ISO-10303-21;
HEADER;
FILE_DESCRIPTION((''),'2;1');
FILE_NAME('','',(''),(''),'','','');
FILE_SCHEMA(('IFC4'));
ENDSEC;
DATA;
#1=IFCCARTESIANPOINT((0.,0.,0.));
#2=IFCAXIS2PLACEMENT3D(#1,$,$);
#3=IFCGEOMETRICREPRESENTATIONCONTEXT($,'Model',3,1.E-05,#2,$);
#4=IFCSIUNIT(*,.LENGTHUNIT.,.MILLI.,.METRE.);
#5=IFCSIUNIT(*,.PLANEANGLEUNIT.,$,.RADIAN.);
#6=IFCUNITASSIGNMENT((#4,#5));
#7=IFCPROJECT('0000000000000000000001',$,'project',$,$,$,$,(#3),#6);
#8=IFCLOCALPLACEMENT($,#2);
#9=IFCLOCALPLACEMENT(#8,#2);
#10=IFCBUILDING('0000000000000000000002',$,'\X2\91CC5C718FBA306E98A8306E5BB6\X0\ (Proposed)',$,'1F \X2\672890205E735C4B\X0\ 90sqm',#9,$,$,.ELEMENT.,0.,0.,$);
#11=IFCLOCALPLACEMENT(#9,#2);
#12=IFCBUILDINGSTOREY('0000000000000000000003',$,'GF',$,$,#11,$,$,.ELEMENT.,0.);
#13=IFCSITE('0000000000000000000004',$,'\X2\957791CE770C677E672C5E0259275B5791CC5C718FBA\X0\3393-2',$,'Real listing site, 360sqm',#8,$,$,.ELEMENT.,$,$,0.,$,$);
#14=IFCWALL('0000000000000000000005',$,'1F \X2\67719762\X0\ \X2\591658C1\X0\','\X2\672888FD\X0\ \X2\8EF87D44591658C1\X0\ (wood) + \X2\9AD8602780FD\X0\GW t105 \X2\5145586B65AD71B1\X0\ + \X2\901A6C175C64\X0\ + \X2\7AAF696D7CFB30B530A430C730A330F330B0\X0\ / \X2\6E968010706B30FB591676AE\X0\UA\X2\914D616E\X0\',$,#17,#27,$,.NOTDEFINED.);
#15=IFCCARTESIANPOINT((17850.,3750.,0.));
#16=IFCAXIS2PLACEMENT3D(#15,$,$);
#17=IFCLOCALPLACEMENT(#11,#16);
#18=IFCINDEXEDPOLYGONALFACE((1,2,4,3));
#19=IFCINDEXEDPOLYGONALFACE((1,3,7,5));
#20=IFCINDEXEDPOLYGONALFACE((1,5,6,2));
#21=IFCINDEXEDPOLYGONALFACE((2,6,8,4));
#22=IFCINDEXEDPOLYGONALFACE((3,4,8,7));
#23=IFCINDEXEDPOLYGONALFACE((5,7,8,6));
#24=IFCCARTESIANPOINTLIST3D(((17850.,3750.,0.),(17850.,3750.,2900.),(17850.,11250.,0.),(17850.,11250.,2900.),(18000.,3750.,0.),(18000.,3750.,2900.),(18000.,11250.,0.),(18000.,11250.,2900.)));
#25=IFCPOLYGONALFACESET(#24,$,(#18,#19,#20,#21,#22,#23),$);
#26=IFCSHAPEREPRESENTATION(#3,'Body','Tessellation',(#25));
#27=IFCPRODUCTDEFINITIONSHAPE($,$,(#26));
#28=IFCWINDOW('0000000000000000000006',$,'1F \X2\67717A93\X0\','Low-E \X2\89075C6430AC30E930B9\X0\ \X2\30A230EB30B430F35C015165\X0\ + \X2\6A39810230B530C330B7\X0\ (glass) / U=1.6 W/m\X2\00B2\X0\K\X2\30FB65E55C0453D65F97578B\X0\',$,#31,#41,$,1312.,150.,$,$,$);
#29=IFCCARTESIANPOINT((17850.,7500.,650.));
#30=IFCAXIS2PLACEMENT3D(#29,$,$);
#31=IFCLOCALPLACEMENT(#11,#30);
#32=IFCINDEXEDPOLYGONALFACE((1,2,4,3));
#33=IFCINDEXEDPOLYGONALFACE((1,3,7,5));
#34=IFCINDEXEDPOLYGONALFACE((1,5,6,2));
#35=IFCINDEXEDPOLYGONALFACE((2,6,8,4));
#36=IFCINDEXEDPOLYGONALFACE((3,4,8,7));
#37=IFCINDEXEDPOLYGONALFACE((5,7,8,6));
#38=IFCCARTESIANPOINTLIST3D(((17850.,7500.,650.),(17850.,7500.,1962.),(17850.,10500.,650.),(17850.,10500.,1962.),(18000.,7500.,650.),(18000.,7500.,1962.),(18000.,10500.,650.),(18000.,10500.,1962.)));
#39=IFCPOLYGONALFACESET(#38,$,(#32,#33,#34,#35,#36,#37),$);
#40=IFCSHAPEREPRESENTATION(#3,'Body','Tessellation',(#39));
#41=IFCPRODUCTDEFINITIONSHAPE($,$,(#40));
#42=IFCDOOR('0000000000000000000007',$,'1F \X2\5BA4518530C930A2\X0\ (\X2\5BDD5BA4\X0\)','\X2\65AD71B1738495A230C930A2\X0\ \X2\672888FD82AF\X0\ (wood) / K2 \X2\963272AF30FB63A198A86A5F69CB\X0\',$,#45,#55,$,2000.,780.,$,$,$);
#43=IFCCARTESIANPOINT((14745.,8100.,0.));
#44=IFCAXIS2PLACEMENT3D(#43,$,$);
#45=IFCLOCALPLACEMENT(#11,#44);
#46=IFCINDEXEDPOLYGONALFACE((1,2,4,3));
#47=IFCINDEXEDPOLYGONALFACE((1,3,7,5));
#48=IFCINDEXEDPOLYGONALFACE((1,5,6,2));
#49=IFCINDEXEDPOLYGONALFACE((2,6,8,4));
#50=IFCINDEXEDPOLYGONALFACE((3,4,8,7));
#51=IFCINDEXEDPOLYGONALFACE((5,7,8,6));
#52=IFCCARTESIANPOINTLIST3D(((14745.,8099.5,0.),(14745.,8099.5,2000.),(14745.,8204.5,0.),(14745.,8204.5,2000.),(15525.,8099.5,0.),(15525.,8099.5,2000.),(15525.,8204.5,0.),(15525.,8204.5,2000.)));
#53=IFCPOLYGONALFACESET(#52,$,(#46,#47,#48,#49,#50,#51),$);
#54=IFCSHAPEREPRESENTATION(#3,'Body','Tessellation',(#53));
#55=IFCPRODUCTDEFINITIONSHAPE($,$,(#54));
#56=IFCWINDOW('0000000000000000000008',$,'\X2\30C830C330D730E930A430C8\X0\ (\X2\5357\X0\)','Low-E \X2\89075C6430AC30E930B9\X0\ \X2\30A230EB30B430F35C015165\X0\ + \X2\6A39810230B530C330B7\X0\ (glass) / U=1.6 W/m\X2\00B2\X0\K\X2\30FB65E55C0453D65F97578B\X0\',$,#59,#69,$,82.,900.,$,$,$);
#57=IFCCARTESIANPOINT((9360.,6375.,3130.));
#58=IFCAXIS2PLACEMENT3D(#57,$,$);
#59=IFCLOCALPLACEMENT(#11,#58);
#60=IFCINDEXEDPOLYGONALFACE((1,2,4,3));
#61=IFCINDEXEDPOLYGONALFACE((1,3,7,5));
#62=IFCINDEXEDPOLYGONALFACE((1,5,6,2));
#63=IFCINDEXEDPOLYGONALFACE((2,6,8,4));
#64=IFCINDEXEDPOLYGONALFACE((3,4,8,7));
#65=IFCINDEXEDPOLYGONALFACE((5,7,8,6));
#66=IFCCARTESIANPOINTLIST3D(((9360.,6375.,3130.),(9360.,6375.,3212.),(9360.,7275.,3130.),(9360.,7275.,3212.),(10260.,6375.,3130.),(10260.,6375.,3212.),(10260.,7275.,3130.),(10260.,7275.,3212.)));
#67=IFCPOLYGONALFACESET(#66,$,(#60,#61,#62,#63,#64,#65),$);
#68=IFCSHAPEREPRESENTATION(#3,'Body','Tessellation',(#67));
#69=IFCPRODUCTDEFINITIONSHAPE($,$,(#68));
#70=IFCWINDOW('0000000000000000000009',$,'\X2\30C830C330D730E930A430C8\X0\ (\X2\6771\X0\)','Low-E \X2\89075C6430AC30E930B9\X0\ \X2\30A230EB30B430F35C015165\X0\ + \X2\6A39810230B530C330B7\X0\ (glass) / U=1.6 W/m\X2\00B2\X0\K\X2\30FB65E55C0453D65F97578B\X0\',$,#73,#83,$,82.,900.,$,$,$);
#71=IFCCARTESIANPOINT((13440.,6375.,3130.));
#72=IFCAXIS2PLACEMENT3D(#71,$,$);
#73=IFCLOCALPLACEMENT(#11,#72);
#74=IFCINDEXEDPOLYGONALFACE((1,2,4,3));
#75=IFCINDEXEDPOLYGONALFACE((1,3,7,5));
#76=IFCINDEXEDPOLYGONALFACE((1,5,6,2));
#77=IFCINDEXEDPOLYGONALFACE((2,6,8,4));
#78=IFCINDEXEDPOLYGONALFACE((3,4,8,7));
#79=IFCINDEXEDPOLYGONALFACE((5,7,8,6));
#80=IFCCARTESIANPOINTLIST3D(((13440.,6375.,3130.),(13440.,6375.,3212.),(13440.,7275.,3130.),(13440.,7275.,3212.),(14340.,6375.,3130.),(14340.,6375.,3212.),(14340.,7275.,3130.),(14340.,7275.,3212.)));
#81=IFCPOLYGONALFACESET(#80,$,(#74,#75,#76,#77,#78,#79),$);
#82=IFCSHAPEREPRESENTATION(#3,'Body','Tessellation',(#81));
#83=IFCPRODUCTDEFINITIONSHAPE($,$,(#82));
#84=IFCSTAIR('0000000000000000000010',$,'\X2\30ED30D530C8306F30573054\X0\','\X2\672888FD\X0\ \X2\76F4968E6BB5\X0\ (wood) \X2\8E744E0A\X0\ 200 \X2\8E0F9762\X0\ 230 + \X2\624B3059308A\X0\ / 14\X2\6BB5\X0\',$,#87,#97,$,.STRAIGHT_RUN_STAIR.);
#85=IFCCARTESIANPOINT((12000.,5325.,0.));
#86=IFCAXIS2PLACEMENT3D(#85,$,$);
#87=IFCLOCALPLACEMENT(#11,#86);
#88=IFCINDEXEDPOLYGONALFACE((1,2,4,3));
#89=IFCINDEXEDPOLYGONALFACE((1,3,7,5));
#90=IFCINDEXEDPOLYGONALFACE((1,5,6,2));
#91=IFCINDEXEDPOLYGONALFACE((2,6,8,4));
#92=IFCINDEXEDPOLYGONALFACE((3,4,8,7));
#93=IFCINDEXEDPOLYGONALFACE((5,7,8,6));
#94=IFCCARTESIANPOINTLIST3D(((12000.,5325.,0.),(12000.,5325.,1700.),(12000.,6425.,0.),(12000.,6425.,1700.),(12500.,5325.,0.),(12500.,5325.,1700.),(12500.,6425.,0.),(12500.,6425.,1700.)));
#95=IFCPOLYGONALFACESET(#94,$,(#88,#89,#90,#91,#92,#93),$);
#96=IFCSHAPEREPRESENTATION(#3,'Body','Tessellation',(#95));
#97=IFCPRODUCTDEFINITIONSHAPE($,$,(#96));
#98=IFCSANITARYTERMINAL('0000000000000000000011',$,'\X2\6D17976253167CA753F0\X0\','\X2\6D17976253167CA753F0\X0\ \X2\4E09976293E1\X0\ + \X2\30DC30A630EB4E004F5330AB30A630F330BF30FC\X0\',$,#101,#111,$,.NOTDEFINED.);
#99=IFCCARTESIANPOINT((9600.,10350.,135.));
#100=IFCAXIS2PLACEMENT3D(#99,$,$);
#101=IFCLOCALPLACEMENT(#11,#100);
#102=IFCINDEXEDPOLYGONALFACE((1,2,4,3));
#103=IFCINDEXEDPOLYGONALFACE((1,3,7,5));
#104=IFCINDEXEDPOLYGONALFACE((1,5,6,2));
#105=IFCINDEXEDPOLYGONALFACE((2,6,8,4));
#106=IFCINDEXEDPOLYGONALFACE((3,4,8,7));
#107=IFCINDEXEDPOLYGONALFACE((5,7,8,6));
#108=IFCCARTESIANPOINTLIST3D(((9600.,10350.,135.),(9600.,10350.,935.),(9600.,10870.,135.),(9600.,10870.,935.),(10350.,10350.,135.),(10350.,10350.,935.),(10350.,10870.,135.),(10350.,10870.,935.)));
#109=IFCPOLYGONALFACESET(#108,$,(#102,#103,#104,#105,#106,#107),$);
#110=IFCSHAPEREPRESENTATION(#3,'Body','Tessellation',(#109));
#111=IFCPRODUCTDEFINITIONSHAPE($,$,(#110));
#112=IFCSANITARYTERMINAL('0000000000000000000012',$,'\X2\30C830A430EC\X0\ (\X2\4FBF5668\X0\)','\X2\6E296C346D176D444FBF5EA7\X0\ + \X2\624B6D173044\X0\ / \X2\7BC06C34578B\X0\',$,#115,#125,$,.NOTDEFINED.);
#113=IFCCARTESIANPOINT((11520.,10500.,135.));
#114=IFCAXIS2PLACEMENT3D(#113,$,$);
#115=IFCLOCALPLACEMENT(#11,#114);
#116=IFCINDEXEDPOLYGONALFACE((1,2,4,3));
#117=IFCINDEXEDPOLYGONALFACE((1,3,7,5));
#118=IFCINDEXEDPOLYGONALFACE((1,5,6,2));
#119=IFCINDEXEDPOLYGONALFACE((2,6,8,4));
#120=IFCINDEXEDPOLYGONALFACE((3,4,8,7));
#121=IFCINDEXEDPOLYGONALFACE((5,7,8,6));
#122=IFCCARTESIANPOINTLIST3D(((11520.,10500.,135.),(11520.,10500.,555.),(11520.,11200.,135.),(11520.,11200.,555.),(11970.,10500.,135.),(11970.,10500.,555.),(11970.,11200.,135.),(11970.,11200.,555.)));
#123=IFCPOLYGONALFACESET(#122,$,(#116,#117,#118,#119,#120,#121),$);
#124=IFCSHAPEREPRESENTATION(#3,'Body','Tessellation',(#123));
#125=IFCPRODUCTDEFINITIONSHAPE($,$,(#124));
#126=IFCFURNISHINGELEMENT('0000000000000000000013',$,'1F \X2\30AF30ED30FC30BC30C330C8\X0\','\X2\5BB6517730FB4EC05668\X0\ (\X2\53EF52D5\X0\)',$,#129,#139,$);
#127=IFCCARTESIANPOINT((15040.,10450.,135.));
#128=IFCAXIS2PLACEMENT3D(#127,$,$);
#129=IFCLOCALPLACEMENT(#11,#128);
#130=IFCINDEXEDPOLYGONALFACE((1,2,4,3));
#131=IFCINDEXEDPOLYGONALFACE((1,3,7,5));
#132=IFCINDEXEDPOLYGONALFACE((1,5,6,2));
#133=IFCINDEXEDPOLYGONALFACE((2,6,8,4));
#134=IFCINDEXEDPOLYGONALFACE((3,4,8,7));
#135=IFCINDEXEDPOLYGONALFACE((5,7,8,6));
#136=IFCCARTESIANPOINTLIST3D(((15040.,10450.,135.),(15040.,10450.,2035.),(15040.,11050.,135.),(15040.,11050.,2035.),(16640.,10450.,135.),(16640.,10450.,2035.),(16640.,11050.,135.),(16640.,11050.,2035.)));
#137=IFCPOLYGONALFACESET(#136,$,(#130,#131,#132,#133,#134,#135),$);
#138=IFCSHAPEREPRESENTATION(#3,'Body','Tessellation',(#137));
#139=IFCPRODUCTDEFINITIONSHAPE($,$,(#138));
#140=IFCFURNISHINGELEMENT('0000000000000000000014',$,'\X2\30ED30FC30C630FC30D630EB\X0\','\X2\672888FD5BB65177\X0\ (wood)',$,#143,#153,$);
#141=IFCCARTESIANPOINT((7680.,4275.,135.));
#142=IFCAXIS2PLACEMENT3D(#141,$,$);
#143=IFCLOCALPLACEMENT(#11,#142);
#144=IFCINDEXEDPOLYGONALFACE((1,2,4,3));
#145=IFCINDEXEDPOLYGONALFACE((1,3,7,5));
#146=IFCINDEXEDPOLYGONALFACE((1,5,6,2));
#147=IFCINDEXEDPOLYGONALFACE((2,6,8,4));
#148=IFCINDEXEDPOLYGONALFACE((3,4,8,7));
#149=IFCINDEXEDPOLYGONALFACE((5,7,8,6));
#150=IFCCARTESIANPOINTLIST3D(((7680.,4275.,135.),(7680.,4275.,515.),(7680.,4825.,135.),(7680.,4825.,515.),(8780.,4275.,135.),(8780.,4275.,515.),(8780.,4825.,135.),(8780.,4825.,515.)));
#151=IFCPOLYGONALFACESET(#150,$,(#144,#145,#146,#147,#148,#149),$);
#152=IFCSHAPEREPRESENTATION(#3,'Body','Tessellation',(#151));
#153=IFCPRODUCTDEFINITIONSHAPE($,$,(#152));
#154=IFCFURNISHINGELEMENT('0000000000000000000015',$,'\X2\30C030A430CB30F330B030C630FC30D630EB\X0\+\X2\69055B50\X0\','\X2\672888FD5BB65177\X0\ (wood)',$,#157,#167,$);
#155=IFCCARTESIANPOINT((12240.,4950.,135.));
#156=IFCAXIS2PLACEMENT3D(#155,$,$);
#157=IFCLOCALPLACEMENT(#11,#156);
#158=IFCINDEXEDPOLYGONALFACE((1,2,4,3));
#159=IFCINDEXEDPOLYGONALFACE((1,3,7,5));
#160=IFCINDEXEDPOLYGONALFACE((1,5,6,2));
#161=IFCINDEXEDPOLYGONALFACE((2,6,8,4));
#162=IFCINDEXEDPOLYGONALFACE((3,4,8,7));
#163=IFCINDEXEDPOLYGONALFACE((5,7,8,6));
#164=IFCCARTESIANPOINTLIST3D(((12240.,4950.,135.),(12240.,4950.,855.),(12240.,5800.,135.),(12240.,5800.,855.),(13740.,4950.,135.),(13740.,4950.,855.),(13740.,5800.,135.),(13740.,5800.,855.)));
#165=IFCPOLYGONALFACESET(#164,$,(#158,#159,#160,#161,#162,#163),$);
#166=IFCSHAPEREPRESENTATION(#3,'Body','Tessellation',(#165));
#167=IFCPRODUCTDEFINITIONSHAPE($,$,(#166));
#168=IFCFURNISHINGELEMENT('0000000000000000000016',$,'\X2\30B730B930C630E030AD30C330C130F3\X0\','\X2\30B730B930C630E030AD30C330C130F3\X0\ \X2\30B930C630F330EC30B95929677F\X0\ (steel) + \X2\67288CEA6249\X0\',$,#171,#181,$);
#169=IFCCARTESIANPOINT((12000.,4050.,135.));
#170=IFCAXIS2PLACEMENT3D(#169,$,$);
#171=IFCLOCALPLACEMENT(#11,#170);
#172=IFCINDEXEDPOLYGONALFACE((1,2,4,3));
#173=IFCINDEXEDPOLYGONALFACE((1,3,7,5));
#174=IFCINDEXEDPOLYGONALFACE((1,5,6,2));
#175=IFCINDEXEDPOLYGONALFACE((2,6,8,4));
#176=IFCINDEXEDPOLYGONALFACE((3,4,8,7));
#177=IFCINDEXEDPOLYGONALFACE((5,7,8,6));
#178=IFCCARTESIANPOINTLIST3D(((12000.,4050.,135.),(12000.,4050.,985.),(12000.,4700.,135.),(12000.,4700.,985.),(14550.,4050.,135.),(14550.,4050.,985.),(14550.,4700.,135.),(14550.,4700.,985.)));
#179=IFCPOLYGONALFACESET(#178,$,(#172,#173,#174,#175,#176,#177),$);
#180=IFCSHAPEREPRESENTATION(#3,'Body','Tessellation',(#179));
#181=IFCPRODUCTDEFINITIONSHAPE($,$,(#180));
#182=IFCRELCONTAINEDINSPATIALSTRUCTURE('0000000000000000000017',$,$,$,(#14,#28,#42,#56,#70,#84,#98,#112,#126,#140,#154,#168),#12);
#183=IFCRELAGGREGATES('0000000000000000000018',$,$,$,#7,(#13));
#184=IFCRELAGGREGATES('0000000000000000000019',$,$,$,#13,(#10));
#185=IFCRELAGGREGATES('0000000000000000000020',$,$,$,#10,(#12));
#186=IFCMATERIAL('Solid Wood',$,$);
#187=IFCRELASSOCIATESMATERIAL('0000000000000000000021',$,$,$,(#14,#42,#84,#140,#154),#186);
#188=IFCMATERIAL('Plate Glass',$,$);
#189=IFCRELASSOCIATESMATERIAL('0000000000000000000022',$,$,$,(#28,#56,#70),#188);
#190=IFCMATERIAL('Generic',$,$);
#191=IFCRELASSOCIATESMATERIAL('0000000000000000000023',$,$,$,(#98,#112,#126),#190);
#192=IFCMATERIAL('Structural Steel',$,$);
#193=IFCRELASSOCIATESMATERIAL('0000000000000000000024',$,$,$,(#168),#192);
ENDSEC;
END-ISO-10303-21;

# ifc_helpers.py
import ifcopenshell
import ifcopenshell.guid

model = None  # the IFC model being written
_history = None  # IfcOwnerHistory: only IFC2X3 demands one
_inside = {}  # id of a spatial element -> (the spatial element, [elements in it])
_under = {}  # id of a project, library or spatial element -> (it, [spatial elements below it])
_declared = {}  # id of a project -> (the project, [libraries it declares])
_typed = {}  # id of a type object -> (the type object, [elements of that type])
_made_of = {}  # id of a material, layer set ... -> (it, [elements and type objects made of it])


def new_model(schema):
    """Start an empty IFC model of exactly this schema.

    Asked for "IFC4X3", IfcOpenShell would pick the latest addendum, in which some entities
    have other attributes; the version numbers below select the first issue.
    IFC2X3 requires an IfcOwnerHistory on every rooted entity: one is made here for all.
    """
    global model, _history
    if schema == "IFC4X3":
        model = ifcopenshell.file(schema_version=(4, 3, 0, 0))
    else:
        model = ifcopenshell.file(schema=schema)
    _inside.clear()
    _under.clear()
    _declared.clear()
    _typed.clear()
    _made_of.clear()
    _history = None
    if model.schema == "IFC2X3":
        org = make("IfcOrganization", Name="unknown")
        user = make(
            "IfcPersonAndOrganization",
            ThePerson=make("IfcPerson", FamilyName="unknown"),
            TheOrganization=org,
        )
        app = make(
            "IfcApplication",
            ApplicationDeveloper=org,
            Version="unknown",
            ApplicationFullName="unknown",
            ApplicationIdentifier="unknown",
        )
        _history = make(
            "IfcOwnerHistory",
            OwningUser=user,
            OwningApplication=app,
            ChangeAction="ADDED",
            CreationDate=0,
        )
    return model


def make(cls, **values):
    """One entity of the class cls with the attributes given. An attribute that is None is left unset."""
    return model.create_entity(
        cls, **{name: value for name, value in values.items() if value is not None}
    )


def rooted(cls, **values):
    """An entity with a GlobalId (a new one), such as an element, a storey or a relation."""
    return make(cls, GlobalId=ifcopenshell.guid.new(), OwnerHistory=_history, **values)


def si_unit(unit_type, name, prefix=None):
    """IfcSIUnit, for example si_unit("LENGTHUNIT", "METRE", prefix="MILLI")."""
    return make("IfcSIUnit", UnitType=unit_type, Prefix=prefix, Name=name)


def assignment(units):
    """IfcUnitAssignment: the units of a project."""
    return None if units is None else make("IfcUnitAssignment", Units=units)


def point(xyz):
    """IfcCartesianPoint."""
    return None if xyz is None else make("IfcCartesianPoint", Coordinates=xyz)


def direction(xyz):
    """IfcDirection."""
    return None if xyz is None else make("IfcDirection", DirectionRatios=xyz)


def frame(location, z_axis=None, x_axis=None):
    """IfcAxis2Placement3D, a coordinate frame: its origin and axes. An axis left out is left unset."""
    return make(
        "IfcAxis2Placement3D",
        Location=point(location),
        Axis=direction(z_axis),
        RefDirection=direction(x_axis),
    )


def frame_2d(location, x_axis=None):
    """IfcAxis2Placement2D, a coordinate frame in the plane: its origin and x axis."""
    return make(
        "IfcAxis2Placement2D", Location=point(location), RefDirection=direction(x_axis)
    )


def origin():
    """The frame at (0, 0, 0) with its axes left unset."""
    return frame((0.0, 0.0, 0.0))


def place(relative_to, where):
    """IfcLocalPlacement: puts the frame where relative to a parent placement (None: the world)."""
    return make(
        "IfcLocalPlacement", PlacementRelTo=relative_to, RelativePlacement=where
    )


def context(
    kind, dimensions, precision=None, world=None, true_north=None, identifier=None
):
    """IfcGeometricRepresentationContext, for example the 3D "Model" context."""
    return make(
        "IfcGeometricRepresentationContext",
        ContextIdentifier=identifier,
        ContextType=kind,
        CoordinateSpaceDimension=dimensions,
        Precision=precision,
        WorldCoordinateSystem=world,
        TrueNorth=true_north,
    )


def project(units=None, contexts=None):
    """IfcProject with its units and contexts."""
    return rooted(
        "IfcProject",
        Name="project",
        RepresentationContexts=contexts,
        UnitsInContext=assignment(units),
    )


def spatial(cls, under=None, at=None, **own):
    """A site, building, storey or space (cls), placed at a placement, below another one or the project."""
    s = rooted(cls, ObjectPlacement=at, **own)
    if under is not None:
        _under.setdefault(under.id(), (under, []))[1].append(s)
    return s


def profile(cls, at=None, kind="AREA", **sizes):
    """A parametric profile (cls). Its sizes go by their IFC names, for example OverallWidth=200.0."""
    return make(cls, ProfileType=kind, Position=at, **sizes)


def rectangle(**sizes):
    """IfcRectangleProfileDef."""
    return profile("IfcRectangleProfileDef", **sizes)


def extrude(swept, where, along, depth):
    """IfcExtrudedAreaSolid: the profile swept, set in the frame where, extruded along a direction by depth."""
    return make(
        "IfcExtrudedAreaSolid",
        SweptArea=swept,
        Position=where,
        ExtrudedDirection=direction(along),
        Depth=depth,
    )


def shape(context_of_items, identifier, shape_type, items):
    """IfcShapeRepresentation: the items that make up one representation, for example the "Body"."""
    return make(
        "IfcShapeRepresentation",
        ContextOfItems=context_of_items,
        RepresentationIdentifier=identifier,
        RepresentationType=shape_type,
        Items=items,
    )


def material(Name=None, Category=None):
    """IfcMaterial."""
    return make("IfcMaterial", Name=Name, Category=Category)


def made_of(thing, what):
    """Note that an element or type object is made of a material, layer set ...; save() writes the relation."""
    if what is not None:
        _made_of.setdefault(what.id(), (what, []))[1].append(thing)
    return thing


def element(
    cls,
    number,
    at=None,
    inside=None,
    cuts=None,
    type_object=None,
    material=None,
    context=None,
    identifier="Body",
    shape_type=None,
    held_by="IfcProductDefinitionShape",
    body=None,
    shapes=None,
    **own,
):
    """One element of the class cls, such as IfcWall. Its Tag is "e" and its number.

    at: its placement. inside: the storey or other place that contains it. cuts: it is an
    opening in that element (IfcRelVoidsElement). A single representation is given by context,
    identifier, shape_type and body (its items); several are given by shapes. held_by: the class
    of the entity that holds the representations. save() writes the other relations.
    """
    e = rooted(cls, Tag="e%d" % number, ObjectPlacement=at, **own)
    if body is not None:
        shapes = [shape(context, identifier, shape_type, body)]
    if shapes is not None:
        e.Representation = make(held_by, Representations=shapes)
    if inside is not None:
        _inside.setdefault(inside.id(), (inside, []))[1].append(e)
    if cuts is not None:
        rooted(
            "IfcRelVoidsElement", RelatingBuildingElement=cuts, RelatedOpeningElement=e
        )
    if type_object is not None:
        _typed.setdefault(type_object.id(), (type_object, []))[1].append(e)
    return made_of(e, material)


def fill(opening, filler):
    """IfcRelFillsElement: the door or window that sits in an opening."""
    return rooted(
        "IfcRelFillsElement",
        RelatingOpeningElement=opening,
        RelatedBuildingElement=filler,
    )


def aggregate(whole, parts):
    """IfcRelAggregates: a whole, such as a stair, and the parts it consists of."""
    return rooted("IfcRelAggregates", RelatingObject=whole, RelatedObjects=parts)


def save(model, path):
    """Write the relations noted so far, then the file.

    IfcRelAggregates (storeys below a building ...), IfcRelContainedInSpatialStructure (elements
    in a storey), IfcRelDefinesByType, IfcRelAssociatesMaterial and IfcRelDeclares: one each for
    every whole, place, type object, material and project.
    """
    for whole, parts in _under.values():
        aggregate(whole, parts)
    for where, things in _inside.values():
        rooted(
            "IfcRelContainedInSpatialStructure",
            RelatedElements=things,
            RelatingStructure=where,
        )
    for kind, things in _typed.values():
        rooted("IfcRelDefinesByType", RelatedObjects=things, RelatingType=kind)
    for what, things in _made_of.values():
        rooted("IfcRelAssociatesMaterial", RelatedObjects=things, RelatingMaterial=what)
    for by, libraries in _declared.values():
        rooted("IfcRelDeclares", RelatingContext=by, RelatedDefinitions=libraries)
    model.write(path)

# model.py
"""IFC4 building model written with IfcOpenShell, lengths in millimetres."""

from ifc_helpers import new_model, si_unit, frame, frame_2d, origin, place, context, project, spatial, rectangle, extrude, material, element, fill, save


model = new_model("IFC4")

# Units and contexts
model_context = context("Model", 3, precision=1e-05, world=origin())
ifc_project = project(units=[si_unit("LENGTHUNIT", "METRE", prefix="MILLI"), si_unit("PLANEANGLEUNIT", "RADIAN")], contexts=[model_context])

# Site, building, storey
site_placement = place(None, origin())
site = spatial("IfcSite", under=ifc_project, at=site_placement, Name="長野県松本市大字里山辺3393-2", ObjectType="Real listing site, 360sqm", CompositionType="ELEMENT", RefElevation=0.0)
building_placement = place(site_placement, origin())
building = spatial("IfcBuilding", under=site, at=building_placement, Name="里山辺の風の家 (Proposed)", ObjectType="1F 木造平屋 90sqm", CompositionType="ELEMENT", ElevationOfRefHeight=0.0, ElevationOfTerrain=0.0)
storey_placement = place(building_placement, origin())
storey = spatial("IfcBuildingStorey", under=building, at=storey_placement, Name="GF", CompositionType="ELEMENT", Elevation=0.0)

# Wall, opening, window
ifc_material_1 = material(Name="Solid Wood")
wall_1_placement = place(storey_placement, frame((17850.0, 3750.0, 0.0)))
wall_1 = element("IfcWall", 1, at=wall_1_placement, inside=storey, material=ifc_material_1, Name="1F 東面 外壁", Description="木製 軸組外壁 (wood) + 高性能GW t105 充填断熱 + 通気層 + 窯業系サイディング / 準耐火・外皮UA配慮", PredefinedType="NOTDEFINED", context=model_context, shape_type="SweptSolid", body=[
    extrude(rectangle(XDim=150.0, YDim=7500.0, at=frame_2d((75.0, 3750.0))), frame((17850.0, 3750.0, 0.0)), (0.0, 0.0, 1.0), 2900.0),
])
opening_placement = place(storey_placement, frame((17850.0, 7500.0, 650.0)))
opening = element("IfcOpeningElement", 2, at=opening_placement, cuts=wall_1, PredefinedType="NOTDEFINED", context=model_context, shape_type="SweptSolid", body=[
    extrude(rectangle(XDim=150.0, YDim=3000.0, at=frame_2d((75.0, 1500.0))), frame((17850.0, 7500.0, 650.0)), (0.0, 0.0, 1.0), 1312.0),
])
ifc_material_2 = material(Name="Plate Glass")
window_1_placement = place(storey_placement, frame((17850.0, 7500.0, 650.0)))
window_1 = element("IfcWindow", 3, at=window_1_placement, inside=storey, material=ifc_material_2, Name="1F 東窓", Description="Low-E 複層ガラス アルゴン封入 + 樹脂サッシ (glass) / U=1.6 W/m²K・日射取得型", OverallHeight=1312.0, OverallWidth=150.0, context=model_context, shape_type="SweptSolid", body=[
    extrude(rectangle(XDim=150.0, YDim=3000.0, at=frame_2d((75.0, 1500.0))), frame((17850.0, 7500.0, 650.0)), (0.0, 0.0, 1.0), 1312.0),
])
fill(opening, window_1)

# Door
door_placement = place(storey_placement, frame((14745.0, 8100.0, 0.0)))
element("IfcDoor", 4, at=door_placement, inside=storey, material=ifc_material_1, Name="1F 室内ドア (寝室)", Description="断熱玄関ドア 木製芯 (wood) / K2 防犯・採風機構", OverallHeight=2000.0, OverallWidth=780.0, context=model_context, shape_type="SweptSolid", body=[
    extrude(rectangle(XDim=780.0, YDim=105.0, at=frame_2d((390.0, 52.0))), frame((14745.0, 8100.0, 0.0)), (0.0, 0.0, 1.0), 2000.0),
])

# Windows
window_2_placement = place(storey_placement, frame((9360.0, 6375.0, 3130.0)))
element("IfcWindow", 5, at=window_2_placement, inside=storey, material=ifc_material_2, Name="トップライト (南)", Description="Low-E 複層ガラス アルゴン封入 + 樹脂サッシ (glass) / U=1.6 W/m²K・日射取得型", OverallHeight=82.0, OverallWidth=900.0, context=model_context, shape_type="SweptSolid", body=[
    extrude(rectangle(XDim=900.0, YDim=900.0, at=frame_2d((450.0, 450.0))), frame((9360.0, 6375.0, 3130.0)), (0.0, 0.0, 1.0), 82.0),
])
window_3_placement = place(storey_placement, frame((13440.0, 6375.0, 3130.0)))
element("IfcWindow", 6, at=window_3_placement, inside=storey, material=ifc_material_2, Name="トップライト (東)", Description="Low-E 複層ガラス アルゴン封入 + 樹脂サッシ (glass) / U=1.6 W/m²K・日射取得型", OverallHeight=82.0, OverallWidth=900.0, context=model_context, shape_type="SweptSolid", body=[
    extrude(rectangle(XDim=900.0, YDim=900.0, at=frame_2d((450.0, 450.0))), frame((13440.0, 6375.0, 3130.0)), (0.0, 0.0, 1.0), 82.0),
])

# Stair
stair_placement = place(storey_placement, frame((12000.0, 5325.0, 0.0)))
element("IfcStair", 7, at=stair_placement, inside=storey, material=ifc_material_1, Name="ロフトはしご", Description="木製 直階段 (wood) 蹴上 200 踏面 230 + 手すり / 14段", PredefinedType="STRAIGHT_RUN_STAIR", context=model_context, shape_type="SweptSolid", body=[
    extrude(rectangle(XDim=500.0, YDim=1100.0, at=frame_2d((250.0, 550.0))), frame((12000.0, 5325.0, 0.0)), (0.0, 0.0, 1.0), 1700.0),
])

# Sanitary terminals
ifc_material_3 = material(Name="Generic")
sanitary_terminal_1_placement = place(storey_placement, frame((9600.0, 10350.0, 135.0)))
element("IfcSanitaryTerminal", 8, at=sanitary_terminal_1_placement, inside=storey, material=ifc_material_3, Name="洗面化粧台", Description="洗面化粧台 三面鏡 + ボウル一体カウンター", PredefinedType="NOTDEFINED", context=model_context, shape_type="SweptSolid", body=[
    extrude(rectangle(XDim=750.0, YDim=520.0, at=frame_2d((375.0, 260.0))), frame((9600.0, 10350.0, 135.0)), (0.0, 0.0, 1.0), 800.0),
])
sanitary_terminal_2_placement = place(storey_placement, frame((11520.0, 10500.0, 135.0)))
element("IfcSanitaryTerminal", 9, at=sanitary_terminal_2_placement, inside=storey, material=ifc_material_3, Name="トイレ (便器)", Description="温水洗浄便座 + 手洗い / 節水型", PredefinedType="NOTDEFINED", context=model_context, shape_type="SweptSolid", body=[
    extrude(rectangle(XDim=450.0, YDim=700.0, at=frame_2d((225.0, 350.0))), frame((11520.0, 10500.0, 135.0)), (0.0, 0.0, 1.0), 420.0),
])

# Furnishing elements
furnishing_1_placement = place(storey_placement, frame((15040.0, 10450.0, 135.0)))
element("IfcFurnishingElement", 10, at=furnishing_1_placement, inside=storey, material=ifc_material_3, Name="1F クローゼット", Description="家具・什器 (可動)", context=model_context, shape_type="SweptSolid", body=[
    extrude(rectangle(XDim=1600.0, YDim=600.0, at=frame_2d((800.0, 300.0))), frame((15040.0, 10450.0, 135.0)), (0.0, 0.0, 1.0), 1900.0),
])
furnishing_2_placement = place(storey_placement, frame((7680.0, 4275.0, 135.0)))
element("IfcFurnishingElement", 11, at=furnishing_2_placement, inside=storey, material=ifc_material_1, Name="ローテーブル", Description="木製家具 (wood)", context=model_context, shape_type="SweptSolid", body=[
    extrude(rectangle(XDim=1100.0, YDim=550.0, at=frame_2d((550.0, 275.0))), frame((7680.0, 4275.0, 135.0)), (0.0, 0.0, 1.0), 380.0),
])
furnishing_3_placement = place(storey_placement, frame((12240.0, 4950.0, 135.0)))
element("IfcFurnishingElement", 12, at=furnishing_3_placement, inside=storey, material=ifc_material_1, Name="ダイニングテーブル+椅子", Description="木製家具 (wood)", context=model_context, shape_type="SweptSolid", body=[
    extrude(rectangle(XDim=1500.0, YDim=850.0, at=frame_2d((750.0, 425.0))), frame((12240.0, 4950.0, 135.0)), (0.0, 0.0, 1.0), 720.0),
])
ifc_material_4 = material(Name="Structural Steel")
furnishing_4_placement = place(storey_placement, frame((12000.0, 4050.0, 135.0)))
element("IfcFurnishingElement", 13, at=furnishing_4_placement, inside=storey, material=ifc_material_4, Name="システムキッチン", Description="システムキッチン ステンレス天板 (steel) + 木質扉", context=model_context, shape_type="SweptSolid", body=[
    extrude(rectangle(XDim=2550.0, YDim=650.0, at=frame_2d((1275.0, 325.0))), frame((12000.0, 4050.0, 135.0)), (0.0, 0.0, 1.0), 850.0),
])

save(model, "model.ifc")
